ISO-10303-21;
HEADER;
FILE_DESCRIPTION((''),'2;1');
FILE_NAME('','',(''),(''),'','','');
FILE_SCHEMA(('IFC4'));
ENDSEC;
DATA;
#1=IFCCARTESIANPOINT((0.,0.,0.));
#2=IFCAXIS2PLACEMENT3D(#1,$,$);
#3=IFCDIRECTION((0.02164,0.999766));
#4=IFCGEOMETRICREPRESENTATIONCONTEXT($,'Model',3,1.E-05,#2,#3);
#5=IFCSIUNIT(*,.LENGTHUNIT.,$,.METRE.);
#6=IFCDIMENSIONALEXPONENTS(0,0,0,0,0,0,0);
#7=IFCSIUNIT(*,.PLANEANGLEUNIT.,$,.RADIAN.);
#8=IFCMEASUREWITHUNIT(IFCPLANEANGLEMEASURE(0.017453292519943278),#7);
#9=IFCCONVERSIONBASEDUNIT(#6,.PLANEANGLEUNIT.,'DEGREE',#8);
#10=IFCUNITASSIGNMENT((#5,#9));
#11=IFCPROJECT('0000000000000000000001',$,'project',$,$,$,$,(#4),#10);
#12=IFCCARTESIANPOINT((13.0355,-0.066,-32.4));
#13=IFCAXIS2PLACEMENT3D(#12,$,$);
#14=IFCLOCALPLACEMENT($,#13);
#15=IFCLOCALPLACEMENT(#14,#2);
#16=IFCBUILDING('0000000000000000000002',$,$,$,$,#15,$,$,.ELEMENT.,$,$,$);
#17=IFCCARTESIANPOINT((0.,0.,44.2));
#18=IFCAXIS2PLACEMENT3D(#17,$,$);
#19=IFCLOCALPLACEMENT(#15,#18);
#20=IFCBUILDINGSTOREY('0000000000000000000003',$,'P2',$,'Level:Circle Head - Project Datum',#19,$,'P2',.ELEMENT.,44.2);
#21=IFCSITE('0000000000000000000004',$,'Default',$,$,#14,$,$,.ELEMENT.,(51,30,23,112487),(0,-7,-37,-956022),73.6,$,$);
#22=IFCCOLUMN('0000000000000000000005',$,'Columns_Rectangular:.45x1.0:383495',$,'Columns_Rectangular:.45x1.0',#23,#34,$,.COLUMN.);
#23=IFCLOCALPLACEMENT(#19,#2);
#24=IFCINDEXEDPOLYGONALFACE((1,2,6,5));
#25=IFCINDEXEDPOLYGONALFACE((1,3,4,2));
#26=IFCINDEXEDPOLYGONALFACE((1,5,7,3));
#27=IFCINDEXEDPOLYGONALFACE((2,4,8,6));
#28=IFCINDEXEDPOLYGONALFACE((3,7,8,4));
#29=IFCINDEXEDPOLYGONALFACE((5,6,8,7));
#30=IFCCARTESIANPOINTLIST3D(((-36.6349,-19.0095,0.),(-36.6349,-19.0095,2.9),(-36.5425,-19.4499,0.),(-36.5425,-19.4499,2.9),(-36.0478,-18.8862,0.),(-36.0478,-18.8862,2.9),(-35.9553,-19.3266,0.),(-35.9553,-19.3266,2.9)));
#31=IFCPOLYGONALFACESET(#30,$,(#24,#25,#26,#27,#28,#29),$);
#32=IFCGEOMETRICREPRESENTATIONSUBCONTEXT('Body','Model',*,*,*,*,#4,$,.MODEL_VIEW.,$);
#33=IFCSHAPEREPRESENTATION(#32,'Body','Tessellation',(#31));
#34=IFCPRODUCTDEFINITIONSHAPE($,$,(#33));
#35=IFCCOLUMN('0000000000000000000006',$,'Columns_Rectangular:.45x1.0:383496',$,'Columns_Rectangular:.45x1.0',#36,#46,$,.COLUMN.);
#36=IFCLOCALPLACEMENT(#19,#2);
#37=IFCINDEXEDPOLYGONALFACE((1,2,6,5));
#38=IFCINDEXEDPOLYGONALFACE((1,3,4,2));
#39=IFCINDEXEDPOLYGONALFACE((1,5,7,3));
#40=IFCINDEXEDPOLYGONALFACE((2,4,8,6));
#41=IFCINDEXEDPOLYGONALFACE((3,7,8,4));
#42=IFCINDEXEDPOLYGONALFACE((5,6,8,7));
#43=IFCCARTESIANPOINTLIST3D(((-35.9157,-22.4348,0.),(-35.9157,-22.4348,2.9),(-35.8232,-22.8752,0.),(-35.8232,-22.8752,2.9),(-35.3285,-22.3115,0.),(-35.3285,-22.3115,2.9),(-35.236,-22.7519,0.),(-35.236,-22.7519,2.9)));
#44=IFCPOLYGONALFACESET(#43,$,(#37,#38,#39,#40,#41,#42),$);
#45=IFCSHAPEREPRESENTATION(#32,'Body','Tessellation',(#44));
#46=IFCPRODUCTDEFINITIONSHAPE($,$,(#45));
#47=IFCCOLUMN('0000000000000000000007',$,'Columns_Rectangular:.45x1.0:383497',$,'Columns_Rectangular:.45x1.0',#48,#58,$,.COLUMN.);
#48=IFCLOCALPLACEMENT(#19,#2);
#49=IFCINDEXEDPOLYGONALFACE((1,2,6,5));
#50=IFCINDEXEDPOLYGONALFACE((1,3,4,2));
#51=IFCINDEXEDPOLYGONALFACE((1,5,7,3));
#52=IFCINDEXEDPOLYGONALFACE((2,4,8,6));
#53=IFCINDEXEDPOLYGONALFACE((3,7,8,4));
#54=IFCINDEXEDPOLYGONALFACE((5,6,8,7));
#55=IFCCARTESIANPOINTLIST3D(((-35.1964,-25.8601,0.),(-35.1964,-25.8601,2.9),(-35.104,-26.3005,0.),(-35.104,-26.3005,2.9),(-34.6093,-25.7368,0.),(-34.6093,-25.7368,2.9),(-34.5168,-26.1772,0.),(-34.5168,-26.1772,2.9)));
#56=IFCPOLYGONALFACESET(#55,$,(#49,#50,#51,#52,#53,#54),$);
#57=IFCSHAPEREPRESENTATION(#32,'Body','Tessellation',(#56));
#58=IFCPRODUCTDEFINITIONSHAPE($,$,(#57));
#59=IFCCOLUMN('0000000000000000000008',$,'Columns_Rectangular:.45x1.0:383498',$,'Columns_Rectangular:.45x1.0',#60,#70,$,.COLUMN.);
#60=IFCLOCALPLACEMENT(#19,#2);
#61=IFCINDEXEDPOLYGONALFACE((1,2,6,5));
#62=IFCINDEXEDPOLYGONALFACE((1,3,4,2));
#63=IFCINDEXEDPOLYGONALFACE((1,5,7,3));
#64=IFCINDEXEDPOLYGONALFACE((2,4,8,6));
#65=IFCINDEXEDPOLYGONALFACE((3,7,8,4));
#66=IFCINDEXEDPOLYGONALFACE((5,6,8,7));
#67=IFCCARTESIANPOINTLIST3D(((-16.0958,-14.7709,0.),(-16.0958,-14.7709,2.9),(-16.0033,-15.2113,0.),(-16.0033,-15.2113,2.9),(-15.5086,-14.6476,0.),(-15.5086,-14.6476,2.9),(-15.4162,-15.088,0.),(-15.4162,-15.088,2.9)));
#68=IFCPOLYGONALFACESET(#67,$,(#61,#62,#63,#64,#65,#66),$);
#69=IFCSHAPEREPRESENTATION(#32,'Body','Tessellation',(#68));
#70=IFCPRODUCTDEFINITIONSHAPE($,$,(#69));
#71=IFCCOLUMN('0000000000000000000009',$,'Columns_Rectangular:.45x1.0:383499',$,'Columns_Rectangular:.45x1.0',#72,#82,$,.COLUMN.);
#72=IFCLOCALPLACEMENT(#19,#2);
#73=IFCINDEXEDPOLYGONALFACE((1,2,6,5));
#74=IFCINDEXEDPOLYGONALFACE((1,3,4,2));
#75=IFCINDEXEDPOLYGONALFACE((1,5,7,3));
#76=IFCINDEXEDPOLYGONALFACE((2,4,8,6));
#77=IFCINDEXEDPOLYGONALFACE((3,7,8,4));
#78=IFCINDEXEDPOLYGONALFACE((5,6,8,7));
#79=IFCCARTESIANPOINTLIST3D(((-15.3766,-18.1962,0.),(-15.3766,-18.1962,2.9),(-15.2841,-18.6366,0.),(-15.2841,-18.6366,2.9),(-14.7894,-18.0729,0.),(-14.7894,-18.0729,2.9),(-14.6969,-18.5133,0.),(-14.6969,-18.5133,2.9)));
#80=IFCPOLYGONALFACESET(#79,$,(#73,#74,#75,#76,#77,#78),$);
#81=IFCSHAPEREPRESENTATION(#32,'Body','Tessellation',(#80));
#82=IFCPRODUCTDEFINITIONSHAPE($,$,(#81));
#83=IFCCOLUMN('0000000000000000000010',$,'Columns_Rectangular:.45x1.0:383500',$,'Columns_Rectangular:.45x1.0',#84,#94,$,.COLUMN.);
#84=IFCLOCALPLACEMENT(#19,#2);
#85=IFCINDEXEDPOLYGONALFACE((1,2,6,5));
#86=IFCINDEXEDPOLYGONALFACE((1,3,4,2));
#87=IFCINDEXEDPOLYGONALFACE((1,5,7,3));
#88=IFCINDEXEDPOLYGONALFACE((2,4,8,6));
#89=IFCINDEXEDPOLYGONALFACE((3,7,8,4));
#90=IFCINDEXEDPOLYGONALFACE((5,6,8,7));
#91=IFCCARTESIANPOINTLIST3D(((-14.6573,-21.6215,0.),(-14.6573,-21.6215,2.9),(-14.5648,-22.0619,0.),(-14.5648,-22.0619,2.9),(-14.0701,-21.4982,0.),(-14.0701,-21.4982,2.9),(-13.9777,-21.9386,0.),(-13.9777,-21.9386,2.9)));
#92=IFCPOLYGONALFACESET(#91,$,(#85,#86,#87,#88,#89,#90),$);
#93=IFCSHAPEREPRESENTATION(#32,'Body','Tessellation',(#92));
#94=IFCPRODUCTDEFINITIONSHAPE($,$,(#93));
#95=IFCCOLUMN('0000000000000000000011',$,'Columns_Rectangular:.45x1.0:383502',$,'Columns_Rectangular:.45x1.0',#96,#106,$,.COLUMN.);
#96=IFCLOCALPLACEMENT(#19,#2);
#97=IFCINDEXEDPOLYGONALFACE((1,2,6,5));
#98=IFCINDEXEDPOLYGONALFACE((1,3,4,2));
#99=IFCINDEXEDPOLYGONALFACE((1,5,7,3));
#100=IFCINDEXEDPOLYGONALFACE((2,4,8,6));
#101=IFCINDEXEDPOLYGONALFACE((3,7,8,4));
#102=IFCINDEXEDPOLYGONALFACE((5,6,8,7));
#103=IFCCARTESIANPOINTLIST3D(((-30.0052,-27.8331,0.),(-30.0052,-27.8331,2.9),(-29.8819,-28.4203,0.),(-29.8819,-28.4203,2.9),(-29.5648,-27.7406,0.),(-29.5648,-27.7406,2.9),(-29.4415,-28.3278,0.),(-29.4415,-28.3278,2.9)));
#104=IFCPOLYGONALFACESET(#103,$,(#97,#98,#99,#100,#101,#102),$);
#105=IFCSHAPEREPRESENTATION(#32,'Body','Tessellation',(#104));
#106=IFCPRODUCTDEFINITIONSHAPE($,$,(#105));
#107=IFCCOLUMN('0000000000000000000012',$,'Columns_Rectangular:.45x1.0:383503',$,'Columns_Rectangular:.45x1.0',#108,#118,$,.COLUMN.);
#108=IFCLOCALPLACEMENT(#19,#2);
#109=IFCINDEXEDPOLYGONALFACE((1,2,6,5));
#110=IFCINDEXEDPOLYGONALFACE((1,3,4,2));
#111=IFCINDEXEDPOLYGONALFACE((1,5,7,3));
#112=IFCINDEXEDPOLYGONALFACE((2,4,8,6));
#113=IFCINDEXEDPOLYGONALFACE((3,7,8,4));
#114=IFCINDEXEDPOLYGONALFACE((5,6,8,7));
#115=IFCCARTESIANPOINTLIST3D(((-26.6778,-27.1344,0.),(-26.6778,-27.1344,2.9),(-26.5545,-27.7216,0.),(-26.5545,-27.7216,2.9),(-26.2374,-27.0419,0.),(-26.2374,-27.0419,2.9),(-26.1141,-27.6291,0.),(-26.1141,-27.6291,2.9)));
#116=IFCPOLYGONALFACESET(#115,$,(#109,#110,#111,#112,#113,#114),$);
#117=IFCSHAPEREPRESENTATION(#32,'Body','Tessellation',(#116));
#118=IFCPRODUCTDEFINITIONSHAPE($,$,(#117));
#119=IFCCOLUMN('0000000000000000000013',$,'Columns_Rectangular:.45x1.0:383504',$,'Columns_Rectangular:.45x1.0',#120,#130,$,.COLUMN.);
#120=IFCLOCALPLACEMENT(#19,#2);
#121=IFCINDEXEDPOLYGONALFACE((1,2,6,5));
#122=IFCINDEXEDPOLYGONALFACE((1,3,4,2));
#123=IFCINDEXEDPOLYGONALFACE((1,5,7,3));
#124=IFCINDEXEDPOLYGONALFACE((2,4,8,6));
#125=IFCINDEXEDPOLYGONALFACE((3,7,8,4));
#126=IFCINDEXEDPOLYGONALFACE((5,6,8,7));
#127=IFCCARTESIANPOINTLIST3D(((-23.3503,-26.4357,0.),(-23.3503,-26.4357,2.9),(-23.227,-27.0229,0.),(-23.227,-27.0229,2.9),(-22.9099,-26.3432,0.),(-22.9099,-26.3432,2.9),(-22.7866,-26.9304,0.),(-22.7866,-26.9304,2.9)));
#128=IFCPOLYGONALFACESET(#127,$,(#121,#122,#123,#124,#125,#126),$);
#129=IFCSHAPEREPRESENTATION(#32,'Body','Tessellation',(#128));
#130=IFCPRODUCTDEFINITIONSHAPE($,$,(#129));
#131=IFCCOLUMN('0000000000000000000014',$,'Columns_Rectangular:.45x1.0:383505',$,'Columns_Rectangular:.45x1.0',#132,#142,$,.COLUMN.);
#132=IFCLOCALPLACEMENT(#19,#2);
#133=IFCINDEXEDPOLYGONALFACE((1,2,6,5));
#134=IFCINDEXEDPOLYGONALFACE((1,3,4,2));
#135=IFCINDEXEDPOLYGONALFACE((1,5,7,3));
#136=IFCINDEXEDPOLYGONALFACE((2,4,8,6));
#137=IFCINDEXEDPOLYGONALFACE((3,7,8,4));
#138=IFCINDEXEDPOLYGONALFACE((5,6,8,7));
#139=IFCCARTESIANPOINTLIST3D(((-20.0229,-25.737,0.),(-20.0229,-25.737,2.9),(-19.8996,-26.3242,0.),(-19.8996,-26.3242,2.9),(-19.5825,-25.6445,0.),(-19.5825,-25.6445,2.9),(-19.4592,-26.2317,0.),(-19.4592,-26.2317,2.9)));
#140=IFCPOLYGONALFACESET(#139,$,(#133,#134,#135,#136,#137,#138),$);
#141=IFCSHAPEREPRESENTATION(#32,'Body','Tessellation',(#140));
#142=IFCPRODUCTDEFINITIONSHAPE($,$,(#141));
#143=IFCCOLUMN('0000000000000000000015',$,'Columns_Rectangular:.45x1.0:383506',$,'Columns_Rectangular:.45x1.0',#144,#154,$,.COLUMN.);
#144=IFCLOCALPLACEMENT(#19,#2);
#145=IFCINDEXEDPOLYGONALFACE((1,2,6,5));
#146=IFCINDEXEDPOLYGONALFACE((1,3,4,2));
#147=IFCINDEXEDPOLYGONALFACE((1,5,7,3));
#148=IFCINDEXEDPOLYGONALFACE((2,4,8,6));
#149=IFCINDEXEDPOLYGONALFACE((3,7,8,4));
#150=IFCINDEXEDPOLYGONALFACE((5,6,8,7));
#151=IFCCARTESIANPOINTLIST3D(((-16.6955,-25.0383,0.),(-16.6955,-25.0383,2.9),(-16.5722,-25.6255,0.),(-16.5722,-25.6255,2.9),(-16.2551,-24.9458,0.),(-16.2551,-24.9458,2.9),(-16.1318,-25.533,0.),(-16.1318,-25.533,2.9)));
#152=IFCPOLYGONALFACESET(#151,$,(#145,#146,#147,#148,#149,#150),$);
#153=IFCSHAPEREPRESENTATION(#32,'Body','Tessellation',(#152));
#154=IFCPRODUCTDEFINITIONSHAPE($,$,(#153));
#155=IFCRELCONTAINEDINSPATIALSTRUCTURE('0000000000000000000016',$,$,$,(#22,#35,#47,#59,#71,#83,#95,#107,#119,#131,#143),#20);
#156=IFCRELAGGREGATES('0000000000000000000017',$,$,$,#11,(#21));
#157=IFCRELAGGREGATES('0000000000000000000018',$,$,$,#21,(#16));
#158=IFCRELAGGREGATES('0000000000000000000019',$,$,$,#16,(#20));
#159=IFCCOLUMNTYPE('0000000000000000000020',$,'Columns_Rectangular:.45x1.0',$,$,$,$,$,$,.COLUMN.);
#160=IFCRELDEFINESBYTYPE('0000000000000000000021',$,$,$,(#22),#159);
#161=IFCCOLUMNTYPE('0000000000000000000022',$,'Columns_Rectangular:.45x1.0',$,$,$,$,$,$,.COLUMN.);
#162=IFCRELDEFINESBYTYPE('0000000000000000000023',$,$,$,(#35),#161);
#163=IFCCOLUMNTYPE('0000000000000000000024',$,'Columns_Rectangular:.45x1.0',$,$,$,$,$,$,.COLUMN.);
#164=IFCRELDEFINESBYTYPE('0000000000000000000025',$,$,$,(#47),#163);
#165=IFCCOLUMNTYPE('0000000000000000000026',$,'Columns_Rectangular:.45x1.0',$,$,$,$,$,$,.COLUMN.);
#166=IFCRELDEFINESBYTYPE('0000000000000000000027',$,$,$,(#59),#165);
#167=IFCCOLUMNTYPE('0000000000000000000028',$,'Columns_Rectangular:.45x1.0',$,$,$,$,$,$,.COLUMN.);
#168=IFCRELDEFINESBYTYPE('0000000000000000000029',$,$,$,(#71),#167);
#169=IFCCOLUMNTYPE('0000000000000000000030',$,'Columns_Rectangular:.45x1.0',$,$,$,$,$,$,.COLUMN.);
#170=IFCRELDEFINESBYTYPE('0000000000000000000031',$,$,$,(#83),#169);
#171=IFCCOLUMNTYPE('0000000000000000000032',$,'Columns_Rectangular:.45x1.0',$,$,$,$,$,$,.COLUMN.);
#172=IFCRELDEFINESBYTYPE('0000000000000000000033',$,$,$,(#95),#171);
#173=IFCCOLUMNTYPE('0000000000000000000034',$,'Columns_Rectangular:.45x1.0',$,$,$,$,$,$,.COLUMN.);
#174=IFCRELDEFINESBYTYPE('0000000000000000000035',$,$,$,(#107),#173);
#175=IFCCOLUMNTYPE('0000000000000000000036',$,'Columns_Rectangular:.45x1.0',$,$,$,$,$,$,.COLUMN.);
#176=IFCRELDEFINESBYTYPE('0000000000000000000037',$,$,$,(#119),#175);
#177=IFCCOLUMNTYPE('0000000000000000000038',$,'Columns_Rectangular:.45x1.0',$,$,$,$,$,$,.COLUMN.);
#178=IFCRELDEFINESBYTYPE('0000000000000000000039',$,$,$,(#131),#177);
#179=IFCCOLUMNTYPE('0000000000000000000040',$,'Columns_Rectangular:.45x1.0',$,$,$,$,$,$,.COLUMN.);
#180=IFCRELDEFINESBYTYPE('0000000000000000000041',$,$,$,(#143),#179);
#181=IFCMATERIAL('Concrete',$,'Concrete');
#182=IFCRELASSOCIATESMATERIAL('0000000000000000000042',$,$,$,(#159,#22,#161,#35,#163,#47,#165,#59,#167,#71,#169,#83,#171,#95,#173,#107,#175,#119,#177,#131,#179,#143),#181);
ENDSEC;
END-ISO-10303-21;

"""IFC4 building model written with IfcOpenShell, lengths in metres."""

from ifc_helpers import new_model, entity, si_unit, converted_unit, direction, frame, origin, place, context, subcontext, project, spatial, indexed_curve, outline, extrude, source, transform, mapped, material, type_object, type_shapes, element, save


model = new_model("IFC4")

# Units and contexts
model_context = context("Model", 3, precision=1e-05, world=origin(), true_north=direction((0.02164, 0.999766)))
body_context = subcontext(model_context, "Body", "Model", "MODEL_VIEW")
ifc_project = project(units=[si_unit("LENGTHUNIT", "METRE"), converted_unit("PLANEANGLEUNIT", "DEGREE", entity("IfcPlaneAngleMeasure", 0.017453292519943278), si_unit("PLANEANGLEUNIT", "RADIAN"), dimensions=[0, 0, 0, 0, 0, 0, 0])], contexts=[model_context])

# Site, building, storey
site_placement = place(None, frame((13.0355, -0.066, -32.4)))
site = spatial("IfcSite", under=ifc_project, at=site_placement, Name="Default", CompositionType="ELEMENT", RefLatitude=(51, 30, 23, 112487), RefLongitude=(0, -7, -37, -956022), RefElevation=73.6)
building_placement = place(site_placement, origin())
building = spatial("IfcBuilding", under=site, at=building_placement, CompositionType="ELEMENT")
storey_placement = place(building_placement, frame((0.0, 0.0, 44.2)))
storey = spatial("IfcBuildingStorey", under=building, at=storey_placement, Name="P2", ObjectType="Level:Circle Head - Project Datum", LongName="P2", CompositionType="ELEMENT", Elevation=44.2)

# Columns
ifc_material = material(Name="Concrete", Category="Concrete")
column_type_1 = type_object("IfcColumnType", Name="Columns_Rectangular:.45x1.0", PredefinedType="COLUMN", material=ifc_material)
shared_shape_1 = source(origin(), body_context, "Body", "SweptSolid", [
    extrude(outline(indexed_curve([(-0.3, -0.225), (0.3, -0.225), (0.3, 0.225), (-0.3, 0.225), (-0.3, -0.225)], self_intersect=False)), frame((-36.2951, -19.168, 44.2), z_axis=(0.0, 0.0, 1.0), x_axis=(0.978657, 0.2055, 0.0)), (0.0, 0.0, 1.0), 2.9),
])
type_shapes(column_type_1, [shared_shape_1])
column_1_placement = place(storey_placement, frame((0.0, 0.0, -44.2)))
element("IfcColumn", 1, at=column_1_placement, inside=storey, type_object=column_type_1, material=ifc_material, Name="Columns_Rectangular:.45x1.0:383495", ObjectType="Columns_Rectangular:.45x1.0", PredefinedType="COLUMN", context=body_context, shape_type="MappedRepresentation", body=[
    mapped(shared_shape_1, transform((0.0, 0.0, 0.0), scale=1.0)),
])
column_type_2 = type_object("IfcColumnType", Name="Columns_Rectangular:.45x1.0", PredefinedType="COLUMN", material=ifc_material)
shared_shape_2 = source(origin(), body_context, "Body", "SweptSolid", [
    extrude(outline(indexed_curve([(-0.3, -0.225), (0.3, -0.225), (0.3, 0.225), (-0.3, 0.225), (-0.3, -0.225)], self_intersect=False)), frame((-35.5759, -22.5933, 44.2), z_axis=(0.0, 0.0, 1.0), x_axis=(0.978657, 0.2055, 0.0)), (0.0, 0.0, 1.0), 2.9),
])
type_shapes(column_type_2, [shared_shape_2])
column_2_placement = place(storey_placement, frame((0.0, 0.0, -44.2)))
element("IfcColumn", 2, at=column_2_placement, inside=storey, type_object=column_type_2, material=ifc_material, Name="Columns_Rectangular:.45x1.0:383496", ObjectType="Columns_Rectangular:.45x1.0", PredefinedType="COLUMN", context=body_context, shape_type="MappedRepresentation", body=[
    mapped(shared_shape_2, transform((0.0, 0.0, 0.0), scale=1.0)),
])
column_type_3 = type_object("IfcColumnType", Name="Columns_Rectangular:.45x1.0", PredefinedType="COLUMN", material=ifc_material)
shared_shape_3 = source(origin(), body_context, "Body", "SweptSolid", [
    extrude(outline(indexed_curve([(-0.3, -0.225), (0.3, -0.225), (0.3, 0.225), (-0.3, 0.225), (-0.3, -0.225)], self_intersect=False)), frame((-34.8566, -26.0186, 44.2), z_axis=(0.0, 0.0, 1.0), x_axis=(0.978657, 0.2055, 0.0)), (0.0, 0.0, 1.0), 2.9),
])
type_shapes(column_type_3, [shared_shape_3])
column_3_placement = place(storey_placement, frame((0.0, 0.0, -44.2)))
element("IfcColumn", 3, at=column_3_placement, inside=storey, type_object=column_type_3, material=ifc_material, Name="Columns_Rectangular:.45x1.0:383497", ObjectType="Columns_Rectangular:.45x1.0", PredefinedType="COLUMN", context=body_context, shape_type="MappedRepresentation", body=[
    mapped(shared_shape_3, transform((0.0, 0.0, 0.0), scale=1.0)),
])
column_type_4 = type_object("IfcColumnType", Name="Columns_Rectangular:.45x1.0", PredefinedType="COLUMN", material=ifc_material)
shared_shape_4 = source(origin(), body_context, "Body", "SweptSolid", [
    extrude(outline(indexed_curve([(-0.3, -0.225), (0.3, -0.225), (0.3, 0.225), (-0.3, 0.225), (-0.3, -0.225)], self_intersect=False)), frame((-15.756, -14.9295, 44.2), z_axis=(0.0, 0.0, 1.0), x_axis=(0.978657, 0.2055, 0.0)), (0.0, 0.0, 1.0), 2.9),
])
type_shapes(column_type_4, [shared_shape_4])
column_4_placement = place(storey_placement, frame((0.0, 0.0, -44.2)))
element("IfcColumn", 4, at=column_4_placement, inside=storey, type_object=column_type_4, material=ifc_material, Name="Columns_Rectangular:.45x1.0:383498", ObjectType="Columns_Rectangular:.45x1.0", PredefinedType="COLUMN", context=body_context, shape_type="MappedRepresentation", body=[
    mapped(shared_shape_4, transform((0.0, 0.0, 0.0), scale=1.0)),
])
column_type_5 = type_object("IfcColumnType", Name="Columns_Rectangular:.45x1.0", PredefinedType="COLUMN", material=ifc_material)
shared_shape_5 = source(origin(), body_context, "Body", "SweptSolid", [
    extrude(outline(indexed_curve([(-0.3, -0.225), (0.3, -0.225), (0.3, 0.225), (-0.3, 0.225), (-0.3, -0.225)], self_intersect=False)), frame((-15.0367, -18.3548, 44.2), z_axis=(0.0, 0.0, 1.0), x_axis=(0.978657, 0.2055, 0.0)), (0.0, 0.0, 1.0), 2.9),
])
type_shapes(column_type_5, [shared_shape_5])
column_5_placement = place(storey_placement, frame((0.0, 0.0, -44.2)))
element("IfcColumn", 5, at=column_5_placement, inside=storey, type_object=column_type_5, material=ifc_material, Name="Columns_Rectangular:.45x1.0:383499", ObjectType="Columns_Rectangular:.45x1.0", PredefinedType="COLUMN", context=body_context, shape_type="MappedRepresentation", body=[
    mapped(shared_shape_5, transform((0.0, 0.0, 0.0), scale=1.0)),
])
column_type_6 = type_object("IfcColumnType", Name="Columns_Rectangular:.45x1.0", PredefinedType="COLUMN", material=ifc_material)
shared_shape_6 = source(origin(), body_context, "Body", "SweptSolid", [
    extrude(outline(indexed_curve([(-0.3, -0.225), (0.3, -0.225), (0.3, 0.225), (-0.3, 0.225), (-0.3, -0.225)], self_intersect=False)), frame((-14.3175, -21.7801, 44.2), z_axis=(0.0, 0.0, 1.0), x_axis=(0.978657, 0.2055, 0.0)), (0.0, 0.0, 1.0), 2.9),
])
type_shapes(column_type_6, [shared_shape_6])
column_6_placement = place(storey_placement, frame((0.0, 0.0, -44.2)))
element("IfcColumn", 6, at=column_6_placement, inside=storey, type_object=column_type_6, material=ifc_material, Name="Columns_Rectangular:.45x1.0:383500", ObjectType="Columns_Rectangular:.45x1.0", PredefinedType="COLUMN", context=body_context, shape_type="MappedRepresentation", body=[
    mapped(shared_shape_6, transform((0.0, 0.0, 0.0), scale=1.0)),
])
column_type_7 = type_object("IfcColumnType", Name="Columns_Rectangular:.45x1.0", PredefinedType="COLUMN", material=ifc_material)
shared_shape_7 = source(origin(), body_context, "Body", "SweptSolid", [
    extrude(outline(indexed_curve([(-0.3, -0.225), (0.3, -0.225), (0.3, 0.225), (-0.3, 0.225), (-0.3, -0.225)], self_intersect=False)), frame((-29.7234, -28.0804, 44.2), z_axis=(0.0, 0.0, 1.0), x_axis=(0.2055, -0.978657, 0.0)), (0.0, 0.0, 1.0), 2.9),
])
type_shapes(column_type_7, [shared_shape_7])
column_7_placement = place(storey_placement, frame((0.0, 0.0, -44.2)))
element("IfcColumn", 7, at=column_7_placement, inside=storey, type_object=column_type_7, material=ifc_material, Name="Columns_Rectangular:.45x1.0:383502", ObjectType="Columns_Rectangular:.45x1.0", PredefinedType="COLUMN", context=body_context, shape_type="MappedRepresentation", body=[
    mapped(shared_shape_7, transform((0.0, 0.0, 0.0), scale=1.0)),
])
column_type_8 = type_object("IfcColumnType", Name="Columns_Rectangular:.45x1.0", PredefinedType="COLUMN", material=ifc_material)
shared_shape_8 = source(origin(), body_context, "Body", "SweptSolid", [
    extrude(outline(indexed_curve([(-0.3, -0.225), (0.3, -0.225), (0.3, 0.225), (-0.3, 0.225), (-0.3, -0.225)], self_intersect=False)), frame((-26.3959, -27.3817, 44.2), z_axis=(0.0, 0.0, 1.0), x_axis=(0.2055, -0.978657, 0.0)), (0.0, 0.0, 1.0), 2.9),
])
type_shapes(column_type_8, [shared_shape_8])
column_8_placement = place(storey_placement, frame((0.0, 0.0, -44.2)))
element("IfcColumn", 8, at=column_8_placement, inside=storey, type_object=column_type_8, material=ifc_material, Name="Columns_Rectangular:.45x1.0:383503", ObjectType="Columns_Rectangular:.45x1.0", PredefinedType="COLUMN", context=body_context, shape_type="MappedRepresentation", body=[
    mapped(shared_shape_8, transform((0.0, 0.0, 0.0), scale=1.0)),
])
column_type_9 = type_object("IfcColumnType", Name="Columns_Rectangular:.45x1.0", PredefinedType="COLUMN", material=ifc_material)
shared_shape_9 = source(origin(), body_context, "Body", "SweptSolid", [
    extrude(outline(indexed_curve([(-0.3, -0.225), (0.3, -0.225), (0.3, 0.225), (-0.3, 0.225), (-0.3, -0.225)], self_intersect=False)), frame((-23.0685, -26.6831, 44.2), z_axis=(0.0, 0.0, 1.0), x_axis=(0.2055, -0.978657, 0.0)), (0.0, 0.0, 1.0), 2.9),
])
type_shapes(column_type_9, [shared_shape_9])
column_9_placement = place(storey_placement, frame((0.0, 0.0, -44.2)))
element("IfcColumn", 9, at=column_9_placement, inside=storey, type_object=column_type_9, material=ifc_material, Name="Columns_Rectangular:.45x1.0:383504", ObjectType="Columns_Rectangular:.45x1.0", PredefinedType="COLUMN", context=body_context, shape_type="MappedRepresentation", body=[
    mapped(shared_shape_9, transform((0.0, 0.0, 0.0), scale=1.0)),
])
column_type_10 = type_object("IfcColumnType", Name="Columns_Rectangular:.45x1.0", PredefinedType="COLUMN", material=ifc_material)
shared_shape_10 = source(origin(), body_context, "Body", "SweptSolid", [
    extrude(outline(indexed_curve([(-0.3, -0.225), (0.3, -0.225), (0.3, 0.225), (-0.3, 0.225), (-0.3, -0.225)], self_intersect=False)), frame((-19.741, -25.9844, 44.2), z_axis=(0.0, 0.0, 1.0), x_axis=(0.2055, -0.978657, 0.0)), (0.0, 0.0, 1.0), 2.9),
])
type_shapes(column_type_10, [shared_shape_10])
column_10_placement = place(storey_placement, frame((0.0, 0.0, -44.2)))
element("IfcColumn", 10, at=column_10_placement, inside=storey, type_object=column_type_10, material=ifc_material, Name="Columns_Rectangular:.45x1.0:383505", ObjectType="Columns_Rectangular:.45x1.0", PredefinedType="COLUMN", context=body_context, shape_type="MappedRepresentation", body=[
    mapped(shared_shape_10, transform((0.0, 0.0, 0.0), scale=1.0)),
])
column_type_11 = type_object("IfcColumnType", Name="Columns_Rectangular:.45x1.0", PredefinedType="COLUMN", material=ifc_material)
shared_shape_11 = source(origin(), body_context, "Body", "SweptSolid", [
    extrude(outline(indexed_curve([(-0.3, -0.225), (0.3, -0.225), (0.3, 0.225), (-0.3, 0.225), (-0.3, -0.225)], self_intersect=False)), frame((-16.4136, -25.2857, 44.2), z_axis=(0.0, 0.0, 1.0), x_axis=(0.2055, -0.978657, 0.0)), (0.0, 0.0, 1.0), 2.9),
])
type_shapes(column_type_11, [shared_shape_11])
column_11_placement = place(storey_placement, frame((0.0, 0.0, -44.2)))
element("IfcColumn", 11, at=column_11_placement, inside=storey, type_object=column_type_11, material=ifc_material, Name="Columns_Rectangular:.45x1.0:383506", ObjectType="Columns_Rectangular:.45x1.0", PredefinedType="COLUMN", context=body_context, shape_type="MappedRepresentation", body=[
    mapped(shared_shape_11, transform((0.0, 0.0, 0.0), scale=1.0)),
])

save(model, "model.ifc")
